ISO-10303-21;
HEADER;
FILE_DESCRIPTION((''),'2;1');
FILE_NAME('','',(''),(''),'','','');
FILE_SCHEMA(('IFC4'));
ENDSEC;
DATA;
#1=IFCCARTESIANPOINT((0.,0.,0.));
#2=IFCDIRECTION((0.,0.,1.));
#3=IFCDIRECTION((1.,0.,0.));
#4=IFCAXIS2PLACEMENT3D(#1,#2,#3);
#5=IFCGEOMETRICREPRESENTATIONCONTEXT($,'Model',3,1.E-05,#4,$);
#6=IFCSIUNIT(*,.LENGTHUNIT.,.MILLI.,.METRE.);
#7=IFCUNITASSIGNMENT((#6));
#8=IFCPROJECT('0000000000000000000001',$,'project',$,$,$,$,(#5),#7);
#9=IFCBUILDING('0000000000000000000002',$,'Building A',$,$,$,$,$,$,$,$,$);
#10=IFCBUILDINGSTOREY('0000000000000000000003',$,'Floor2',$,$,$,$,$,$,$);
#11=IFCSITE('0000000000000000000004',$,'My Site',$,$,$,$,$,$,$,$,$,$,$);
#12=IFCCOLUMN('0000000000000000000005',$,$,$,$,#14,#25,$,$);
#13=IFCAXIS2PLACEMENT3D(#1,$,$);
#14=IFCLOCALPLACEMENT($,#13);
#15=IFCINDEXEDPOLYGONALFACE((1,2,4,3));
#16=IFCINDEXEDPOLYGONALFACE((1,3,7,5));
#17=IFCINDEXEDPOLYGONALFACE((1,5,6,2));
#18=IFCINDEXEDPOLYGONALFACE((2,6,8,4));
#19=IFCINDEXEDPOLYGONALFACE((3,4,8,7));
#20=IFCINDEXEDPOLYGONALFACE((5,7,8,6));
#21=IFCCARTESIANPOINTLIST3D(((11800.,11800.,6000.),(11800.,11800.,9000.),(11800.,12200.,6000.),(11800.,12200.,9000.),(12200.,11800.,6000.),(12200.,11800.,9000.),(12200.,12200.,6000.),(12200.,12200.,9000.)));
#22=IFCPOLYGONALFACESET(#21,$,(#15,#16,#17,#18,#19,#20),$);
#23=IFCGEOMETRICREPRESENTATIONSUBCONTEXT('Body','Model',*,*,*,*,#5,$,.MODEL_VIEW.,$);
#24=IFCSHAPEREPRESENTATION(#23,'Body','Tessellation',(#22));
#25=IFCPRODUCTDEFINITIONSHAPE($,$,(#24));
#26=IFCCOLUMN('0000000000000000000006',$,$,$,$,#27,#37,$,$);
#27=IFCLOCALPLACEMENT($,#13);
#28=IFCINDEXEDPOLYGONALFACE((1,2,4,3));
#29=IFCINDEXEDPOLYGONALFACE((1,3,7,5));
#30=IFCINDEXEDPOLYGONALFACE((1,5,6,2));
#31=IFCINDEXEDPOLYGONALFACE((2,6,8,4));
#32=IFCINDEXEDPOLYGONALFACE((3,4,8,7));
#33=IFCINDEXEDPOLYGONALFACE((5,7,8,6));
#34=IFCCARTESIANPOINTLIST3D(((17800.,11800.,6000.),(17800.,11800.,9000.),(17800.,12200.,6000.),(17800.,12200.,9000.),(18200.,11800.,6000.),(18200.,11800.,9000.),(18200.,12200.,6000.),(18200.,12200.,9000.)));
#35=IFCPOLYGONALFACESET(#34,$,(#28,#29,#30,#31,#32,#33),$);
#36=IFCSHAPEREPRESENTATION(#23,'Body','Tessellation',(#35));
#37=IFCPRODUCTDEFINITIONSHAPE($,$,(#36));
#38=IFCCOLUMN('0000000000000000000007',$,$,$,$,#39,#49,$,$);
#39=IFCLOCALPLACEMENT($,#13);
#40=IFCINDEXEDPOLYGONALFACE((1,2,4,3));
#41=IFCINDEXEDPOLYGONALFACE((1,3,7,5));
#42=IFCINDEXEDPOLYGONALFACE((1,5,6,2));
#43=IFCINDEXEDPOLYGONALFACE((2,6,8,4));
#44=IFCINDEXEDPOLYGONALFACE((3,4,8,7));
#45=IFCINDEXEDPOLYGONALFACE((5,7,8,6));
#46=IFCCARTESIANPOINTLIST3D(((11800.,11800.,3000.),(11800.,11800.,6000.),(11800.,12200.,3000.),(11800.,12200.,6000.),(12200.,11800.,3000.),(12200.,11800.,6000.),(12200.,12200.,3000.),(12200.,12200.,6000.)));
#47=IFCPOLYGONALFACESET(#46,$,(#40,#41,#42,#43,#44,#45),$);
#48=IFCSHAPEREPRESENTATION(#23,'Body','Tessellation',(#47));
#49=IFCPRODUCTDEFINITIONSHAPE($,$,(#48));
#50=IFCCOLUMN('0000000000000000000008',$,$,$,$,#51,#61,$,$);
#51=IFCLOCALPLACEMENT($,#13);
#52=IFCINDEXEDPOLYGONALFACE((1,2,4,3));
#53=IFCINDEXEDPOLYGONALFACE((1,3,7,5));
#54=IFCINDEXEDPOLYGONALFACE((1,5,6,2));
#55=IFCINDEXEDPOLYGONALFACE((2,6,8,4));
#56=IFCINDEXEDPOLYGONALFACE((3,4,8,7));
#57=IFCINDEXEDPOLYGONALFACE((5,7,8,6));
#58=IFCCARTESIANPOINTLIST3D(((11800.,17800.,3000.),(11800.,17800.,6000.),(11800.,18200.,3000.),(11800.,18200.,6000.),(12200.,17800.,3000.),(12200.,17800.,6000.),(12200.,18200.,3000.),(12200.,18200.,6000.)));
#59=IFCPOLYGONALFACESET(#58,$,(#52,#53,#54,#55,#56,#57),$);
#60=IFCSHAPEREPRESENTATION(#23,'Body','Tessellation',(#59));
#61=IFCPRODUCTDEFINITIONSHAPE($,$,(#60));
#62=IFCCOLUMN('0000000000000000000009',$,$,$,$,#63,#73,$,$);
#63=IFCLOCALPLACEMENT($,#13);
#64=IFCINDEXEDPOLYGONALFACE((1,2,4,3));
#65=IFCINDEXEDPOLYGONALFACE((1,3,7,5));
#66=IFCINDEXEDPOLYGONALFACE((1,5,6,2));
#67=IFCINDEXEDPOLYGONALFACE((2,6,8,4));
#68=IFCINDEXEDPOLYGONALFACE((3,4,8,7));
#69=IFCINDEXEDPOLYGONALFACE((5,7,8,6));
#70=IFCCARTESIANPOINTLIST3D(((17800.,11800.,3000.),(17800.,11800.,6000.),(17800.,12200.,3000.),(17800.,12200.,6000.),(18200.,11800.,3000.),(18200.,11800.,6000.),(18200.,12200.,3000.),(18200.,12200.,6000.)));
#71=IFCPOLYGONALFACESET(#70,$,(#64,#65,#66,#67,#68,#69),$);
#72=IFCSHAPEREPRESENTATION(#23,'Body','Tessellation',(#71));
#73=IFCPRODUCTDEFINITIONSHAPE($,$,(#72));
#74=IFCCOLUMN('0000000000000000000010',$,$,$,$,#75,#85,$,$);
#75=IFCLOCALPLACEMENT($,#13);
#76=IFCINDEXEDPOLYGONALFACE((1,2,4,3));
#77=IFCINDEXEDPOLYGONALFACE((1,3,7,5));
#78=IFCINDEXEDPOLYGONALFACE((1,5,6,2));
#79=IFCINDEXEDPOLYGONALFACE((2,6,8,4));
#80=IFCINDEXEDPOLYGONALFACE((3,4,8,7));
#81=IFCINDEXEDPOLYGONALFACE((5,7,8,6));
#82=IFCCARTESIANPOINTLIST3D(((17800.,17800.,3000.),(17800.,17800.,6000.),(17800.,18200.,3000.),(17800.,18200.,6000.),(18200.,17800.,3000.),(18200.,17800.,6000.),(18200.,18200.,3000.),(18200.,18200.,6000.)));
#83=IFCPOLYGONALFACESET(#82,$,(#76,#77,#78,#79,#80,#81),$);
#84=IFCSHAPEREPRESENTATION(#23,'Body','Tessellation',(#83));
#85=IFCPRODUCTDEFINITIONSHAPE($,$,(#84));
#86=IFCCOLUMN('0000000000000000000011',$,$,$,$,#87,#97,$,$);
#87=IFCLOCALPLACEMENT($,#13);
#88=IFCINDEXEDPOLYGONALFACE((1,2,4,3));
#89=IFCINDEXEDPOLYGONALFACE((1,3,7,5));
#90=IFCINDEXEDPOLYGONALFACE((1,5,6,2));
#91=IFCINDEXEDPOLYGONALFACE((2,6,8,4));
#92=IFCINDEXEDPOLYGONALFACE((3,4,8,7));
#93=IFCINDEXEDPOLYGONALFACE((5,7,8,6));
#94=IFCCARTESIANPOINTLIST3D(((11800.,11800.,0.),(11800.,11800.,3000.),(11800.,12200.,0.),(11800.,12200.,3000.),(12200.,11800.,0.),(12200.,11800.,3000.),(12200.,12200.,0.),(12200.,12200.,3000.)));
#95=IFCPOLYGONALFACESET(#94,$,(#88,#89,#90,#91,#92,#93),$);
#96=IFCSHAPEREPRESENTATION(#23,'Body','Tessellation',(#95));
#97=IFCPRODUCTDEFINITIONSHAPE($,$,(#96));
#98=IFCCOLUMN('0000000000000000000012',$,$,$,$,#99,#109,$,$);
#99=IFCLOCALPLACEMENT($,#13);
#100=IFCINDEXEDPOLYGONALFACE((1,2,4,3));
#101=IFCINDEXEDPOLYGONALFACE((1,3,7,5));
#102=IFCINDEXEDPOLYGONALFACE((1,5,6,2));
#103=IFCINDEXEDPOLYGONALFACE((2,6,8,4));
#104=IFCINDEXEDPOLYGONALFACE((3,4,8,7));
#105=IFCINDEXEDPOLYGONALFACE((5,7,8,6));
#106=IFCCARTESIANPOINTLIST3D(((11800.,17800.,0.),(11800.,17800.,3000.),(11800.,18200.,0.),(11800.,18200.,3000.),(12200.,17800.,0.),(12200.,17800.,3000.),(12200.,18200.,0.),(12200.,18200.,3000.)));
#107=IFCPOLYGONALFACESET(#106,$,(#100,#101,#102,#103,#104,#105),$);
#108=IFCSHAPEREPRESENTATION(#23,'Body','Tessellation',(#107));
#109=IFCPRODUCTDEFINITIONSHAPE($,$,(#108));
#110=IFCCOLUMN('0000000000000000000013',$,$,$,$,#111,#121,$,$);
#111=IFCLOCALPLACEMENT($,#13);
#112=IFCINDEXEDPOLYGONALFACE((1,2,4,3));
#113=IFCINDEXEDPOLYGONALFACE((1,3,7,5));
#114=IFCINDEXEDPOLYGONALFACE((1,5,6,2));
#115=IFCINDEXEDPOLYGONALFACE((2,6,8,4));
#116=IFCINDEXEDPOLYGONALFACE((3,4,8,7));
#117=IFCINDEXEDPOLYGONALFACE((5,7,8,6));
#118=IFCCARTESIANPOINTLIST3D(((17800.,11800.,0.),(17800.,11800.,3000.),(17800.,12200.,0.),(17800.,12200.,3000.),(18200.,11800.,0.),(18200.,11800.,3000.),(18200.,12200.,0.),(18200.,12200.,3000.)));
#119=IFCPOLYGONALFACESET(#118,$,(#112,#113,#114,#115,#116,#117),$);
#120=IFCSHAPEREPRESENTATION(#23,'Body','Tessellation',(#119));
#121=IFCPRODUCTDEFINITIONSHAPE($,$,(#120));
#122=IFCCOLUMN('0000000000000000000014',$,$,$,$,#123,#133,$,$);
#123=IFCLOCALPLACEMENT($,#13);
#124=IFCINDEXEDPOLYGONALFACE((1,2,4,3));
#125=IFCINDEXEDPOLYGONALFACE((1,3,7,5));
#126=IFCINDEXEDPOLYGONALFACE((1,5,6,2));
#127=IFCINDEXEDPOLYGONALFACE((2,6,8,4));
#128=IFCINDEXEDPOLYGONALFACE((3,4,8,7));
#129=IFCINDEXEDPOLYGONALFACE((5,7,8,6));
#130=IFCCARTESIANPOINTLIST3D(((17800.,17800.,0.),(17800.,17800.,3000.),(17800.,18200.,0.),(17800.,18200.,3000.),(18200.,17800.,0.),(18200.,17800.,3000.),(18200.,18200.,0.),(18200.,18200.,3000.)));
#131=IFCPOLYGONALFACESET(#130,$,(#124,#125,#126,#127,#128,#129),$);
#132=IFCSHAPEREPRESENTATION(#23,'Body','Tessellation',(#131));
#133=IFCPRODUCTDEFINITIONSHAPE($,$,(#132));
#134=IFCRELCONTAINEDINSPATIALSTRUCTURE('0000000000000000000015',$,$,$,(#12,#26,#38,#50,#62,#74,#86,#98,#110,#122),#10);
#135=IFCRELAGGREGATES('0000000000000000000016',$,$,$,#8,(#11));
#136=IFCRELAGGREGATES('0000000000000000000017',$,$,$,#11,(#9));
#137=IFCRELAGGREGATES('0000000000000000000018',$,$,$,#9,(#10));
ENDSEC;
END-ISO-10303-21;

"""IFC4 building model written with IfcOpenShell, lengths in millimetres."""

from ifc_helpers import new_model, si_unit, frame, origin_with_axes, place, context, subcontext, project, spatial, line, indexed_curve, outline, extrude, element, save


model = new_model("IFC4")

# Units and contexts
model_context = context("Model", 3, precision=1e-05, world=origin_with_axes())
body_context = subcontext(model_context, "Body", "Model", "MODEL_VIEW")
ifc_project = project(units=[si_unit("LENGTHUNIT", "METRE", prefix="MILLI")], contexts=[model_context])

# Site, building, storey
site = spatial("IfcSite", under=ifc_project, Name="My Site")
building = spatial("IfcBuilding", under=site, Name="Building A")
storey = spatial("IfcBuildingStorey", under=building, Name="Floor2")

# Columns
for number, where, z_axis, x_axis in (
    (1, (12000.0, 12000.0, 6000.0), (0.0, 0.0, 1.0), (1.0, 0.0, 0.0)),
    (2, (18000.0, 12000.0, 6000.0), (0.0, 0.0, 1.0), (1.0, 0.0, 0.0)),
    (3, (12000.0, 12000.0, 3000.0), (0.0, 0.0, 1.0), (1.0, 0.0, 0.0)),
    (4, (12000.0, 18000.0, 3000.0), (0.0, 0.0, 1.0), (1.0, 0.0, 0.0)),
    (5, (18000.0, 12000.0, 3000.0), (0.0, 0.0, 1.0), (1.0, 0.0, 0.0)),
    (6, (18000.0, 18000.0, 3000.0), (0.0, 0.0, 1.0), (1.0, 0.0, 0.0)),
    (7, (12000.0, 12000.0, 0.0), (0.0, 0.0, 1.0), (1.0, 0.0, 0.0)),
    (8, (12000.0, 18000.0, 0.0), (0.0, 0.0, 1.0), (1.0, 0.0, 0.0)),
    (9, (18000.0, 12000.0, 0.0), (0.0, 0.0, 1.0), (1.0, 0.0, 0.0)),
    (10, (18000.0, 18000.0, 0.0), (0.0, 0.0, 1.0), (1.0, 0.0, 0.0)),
):
    element("IfcColumn", number, at=place(None, frame(where, z_axis=z_axis, x_axis=x_axis)), inside=storey, context=body_context, shape_type="SweptSolid", body=[
        extrude(outline(indexed_curve([(-200.0, -200.0), (200.0, -200.0), (200.0, 200.0), (-200.0, 200.0)], segments=[line(1, 2, 3, 4, 1)])), origin_with_axes(), (0.0, 0.0, 1.0), 3000.0),
    ])

save(model, "model.ifc")
